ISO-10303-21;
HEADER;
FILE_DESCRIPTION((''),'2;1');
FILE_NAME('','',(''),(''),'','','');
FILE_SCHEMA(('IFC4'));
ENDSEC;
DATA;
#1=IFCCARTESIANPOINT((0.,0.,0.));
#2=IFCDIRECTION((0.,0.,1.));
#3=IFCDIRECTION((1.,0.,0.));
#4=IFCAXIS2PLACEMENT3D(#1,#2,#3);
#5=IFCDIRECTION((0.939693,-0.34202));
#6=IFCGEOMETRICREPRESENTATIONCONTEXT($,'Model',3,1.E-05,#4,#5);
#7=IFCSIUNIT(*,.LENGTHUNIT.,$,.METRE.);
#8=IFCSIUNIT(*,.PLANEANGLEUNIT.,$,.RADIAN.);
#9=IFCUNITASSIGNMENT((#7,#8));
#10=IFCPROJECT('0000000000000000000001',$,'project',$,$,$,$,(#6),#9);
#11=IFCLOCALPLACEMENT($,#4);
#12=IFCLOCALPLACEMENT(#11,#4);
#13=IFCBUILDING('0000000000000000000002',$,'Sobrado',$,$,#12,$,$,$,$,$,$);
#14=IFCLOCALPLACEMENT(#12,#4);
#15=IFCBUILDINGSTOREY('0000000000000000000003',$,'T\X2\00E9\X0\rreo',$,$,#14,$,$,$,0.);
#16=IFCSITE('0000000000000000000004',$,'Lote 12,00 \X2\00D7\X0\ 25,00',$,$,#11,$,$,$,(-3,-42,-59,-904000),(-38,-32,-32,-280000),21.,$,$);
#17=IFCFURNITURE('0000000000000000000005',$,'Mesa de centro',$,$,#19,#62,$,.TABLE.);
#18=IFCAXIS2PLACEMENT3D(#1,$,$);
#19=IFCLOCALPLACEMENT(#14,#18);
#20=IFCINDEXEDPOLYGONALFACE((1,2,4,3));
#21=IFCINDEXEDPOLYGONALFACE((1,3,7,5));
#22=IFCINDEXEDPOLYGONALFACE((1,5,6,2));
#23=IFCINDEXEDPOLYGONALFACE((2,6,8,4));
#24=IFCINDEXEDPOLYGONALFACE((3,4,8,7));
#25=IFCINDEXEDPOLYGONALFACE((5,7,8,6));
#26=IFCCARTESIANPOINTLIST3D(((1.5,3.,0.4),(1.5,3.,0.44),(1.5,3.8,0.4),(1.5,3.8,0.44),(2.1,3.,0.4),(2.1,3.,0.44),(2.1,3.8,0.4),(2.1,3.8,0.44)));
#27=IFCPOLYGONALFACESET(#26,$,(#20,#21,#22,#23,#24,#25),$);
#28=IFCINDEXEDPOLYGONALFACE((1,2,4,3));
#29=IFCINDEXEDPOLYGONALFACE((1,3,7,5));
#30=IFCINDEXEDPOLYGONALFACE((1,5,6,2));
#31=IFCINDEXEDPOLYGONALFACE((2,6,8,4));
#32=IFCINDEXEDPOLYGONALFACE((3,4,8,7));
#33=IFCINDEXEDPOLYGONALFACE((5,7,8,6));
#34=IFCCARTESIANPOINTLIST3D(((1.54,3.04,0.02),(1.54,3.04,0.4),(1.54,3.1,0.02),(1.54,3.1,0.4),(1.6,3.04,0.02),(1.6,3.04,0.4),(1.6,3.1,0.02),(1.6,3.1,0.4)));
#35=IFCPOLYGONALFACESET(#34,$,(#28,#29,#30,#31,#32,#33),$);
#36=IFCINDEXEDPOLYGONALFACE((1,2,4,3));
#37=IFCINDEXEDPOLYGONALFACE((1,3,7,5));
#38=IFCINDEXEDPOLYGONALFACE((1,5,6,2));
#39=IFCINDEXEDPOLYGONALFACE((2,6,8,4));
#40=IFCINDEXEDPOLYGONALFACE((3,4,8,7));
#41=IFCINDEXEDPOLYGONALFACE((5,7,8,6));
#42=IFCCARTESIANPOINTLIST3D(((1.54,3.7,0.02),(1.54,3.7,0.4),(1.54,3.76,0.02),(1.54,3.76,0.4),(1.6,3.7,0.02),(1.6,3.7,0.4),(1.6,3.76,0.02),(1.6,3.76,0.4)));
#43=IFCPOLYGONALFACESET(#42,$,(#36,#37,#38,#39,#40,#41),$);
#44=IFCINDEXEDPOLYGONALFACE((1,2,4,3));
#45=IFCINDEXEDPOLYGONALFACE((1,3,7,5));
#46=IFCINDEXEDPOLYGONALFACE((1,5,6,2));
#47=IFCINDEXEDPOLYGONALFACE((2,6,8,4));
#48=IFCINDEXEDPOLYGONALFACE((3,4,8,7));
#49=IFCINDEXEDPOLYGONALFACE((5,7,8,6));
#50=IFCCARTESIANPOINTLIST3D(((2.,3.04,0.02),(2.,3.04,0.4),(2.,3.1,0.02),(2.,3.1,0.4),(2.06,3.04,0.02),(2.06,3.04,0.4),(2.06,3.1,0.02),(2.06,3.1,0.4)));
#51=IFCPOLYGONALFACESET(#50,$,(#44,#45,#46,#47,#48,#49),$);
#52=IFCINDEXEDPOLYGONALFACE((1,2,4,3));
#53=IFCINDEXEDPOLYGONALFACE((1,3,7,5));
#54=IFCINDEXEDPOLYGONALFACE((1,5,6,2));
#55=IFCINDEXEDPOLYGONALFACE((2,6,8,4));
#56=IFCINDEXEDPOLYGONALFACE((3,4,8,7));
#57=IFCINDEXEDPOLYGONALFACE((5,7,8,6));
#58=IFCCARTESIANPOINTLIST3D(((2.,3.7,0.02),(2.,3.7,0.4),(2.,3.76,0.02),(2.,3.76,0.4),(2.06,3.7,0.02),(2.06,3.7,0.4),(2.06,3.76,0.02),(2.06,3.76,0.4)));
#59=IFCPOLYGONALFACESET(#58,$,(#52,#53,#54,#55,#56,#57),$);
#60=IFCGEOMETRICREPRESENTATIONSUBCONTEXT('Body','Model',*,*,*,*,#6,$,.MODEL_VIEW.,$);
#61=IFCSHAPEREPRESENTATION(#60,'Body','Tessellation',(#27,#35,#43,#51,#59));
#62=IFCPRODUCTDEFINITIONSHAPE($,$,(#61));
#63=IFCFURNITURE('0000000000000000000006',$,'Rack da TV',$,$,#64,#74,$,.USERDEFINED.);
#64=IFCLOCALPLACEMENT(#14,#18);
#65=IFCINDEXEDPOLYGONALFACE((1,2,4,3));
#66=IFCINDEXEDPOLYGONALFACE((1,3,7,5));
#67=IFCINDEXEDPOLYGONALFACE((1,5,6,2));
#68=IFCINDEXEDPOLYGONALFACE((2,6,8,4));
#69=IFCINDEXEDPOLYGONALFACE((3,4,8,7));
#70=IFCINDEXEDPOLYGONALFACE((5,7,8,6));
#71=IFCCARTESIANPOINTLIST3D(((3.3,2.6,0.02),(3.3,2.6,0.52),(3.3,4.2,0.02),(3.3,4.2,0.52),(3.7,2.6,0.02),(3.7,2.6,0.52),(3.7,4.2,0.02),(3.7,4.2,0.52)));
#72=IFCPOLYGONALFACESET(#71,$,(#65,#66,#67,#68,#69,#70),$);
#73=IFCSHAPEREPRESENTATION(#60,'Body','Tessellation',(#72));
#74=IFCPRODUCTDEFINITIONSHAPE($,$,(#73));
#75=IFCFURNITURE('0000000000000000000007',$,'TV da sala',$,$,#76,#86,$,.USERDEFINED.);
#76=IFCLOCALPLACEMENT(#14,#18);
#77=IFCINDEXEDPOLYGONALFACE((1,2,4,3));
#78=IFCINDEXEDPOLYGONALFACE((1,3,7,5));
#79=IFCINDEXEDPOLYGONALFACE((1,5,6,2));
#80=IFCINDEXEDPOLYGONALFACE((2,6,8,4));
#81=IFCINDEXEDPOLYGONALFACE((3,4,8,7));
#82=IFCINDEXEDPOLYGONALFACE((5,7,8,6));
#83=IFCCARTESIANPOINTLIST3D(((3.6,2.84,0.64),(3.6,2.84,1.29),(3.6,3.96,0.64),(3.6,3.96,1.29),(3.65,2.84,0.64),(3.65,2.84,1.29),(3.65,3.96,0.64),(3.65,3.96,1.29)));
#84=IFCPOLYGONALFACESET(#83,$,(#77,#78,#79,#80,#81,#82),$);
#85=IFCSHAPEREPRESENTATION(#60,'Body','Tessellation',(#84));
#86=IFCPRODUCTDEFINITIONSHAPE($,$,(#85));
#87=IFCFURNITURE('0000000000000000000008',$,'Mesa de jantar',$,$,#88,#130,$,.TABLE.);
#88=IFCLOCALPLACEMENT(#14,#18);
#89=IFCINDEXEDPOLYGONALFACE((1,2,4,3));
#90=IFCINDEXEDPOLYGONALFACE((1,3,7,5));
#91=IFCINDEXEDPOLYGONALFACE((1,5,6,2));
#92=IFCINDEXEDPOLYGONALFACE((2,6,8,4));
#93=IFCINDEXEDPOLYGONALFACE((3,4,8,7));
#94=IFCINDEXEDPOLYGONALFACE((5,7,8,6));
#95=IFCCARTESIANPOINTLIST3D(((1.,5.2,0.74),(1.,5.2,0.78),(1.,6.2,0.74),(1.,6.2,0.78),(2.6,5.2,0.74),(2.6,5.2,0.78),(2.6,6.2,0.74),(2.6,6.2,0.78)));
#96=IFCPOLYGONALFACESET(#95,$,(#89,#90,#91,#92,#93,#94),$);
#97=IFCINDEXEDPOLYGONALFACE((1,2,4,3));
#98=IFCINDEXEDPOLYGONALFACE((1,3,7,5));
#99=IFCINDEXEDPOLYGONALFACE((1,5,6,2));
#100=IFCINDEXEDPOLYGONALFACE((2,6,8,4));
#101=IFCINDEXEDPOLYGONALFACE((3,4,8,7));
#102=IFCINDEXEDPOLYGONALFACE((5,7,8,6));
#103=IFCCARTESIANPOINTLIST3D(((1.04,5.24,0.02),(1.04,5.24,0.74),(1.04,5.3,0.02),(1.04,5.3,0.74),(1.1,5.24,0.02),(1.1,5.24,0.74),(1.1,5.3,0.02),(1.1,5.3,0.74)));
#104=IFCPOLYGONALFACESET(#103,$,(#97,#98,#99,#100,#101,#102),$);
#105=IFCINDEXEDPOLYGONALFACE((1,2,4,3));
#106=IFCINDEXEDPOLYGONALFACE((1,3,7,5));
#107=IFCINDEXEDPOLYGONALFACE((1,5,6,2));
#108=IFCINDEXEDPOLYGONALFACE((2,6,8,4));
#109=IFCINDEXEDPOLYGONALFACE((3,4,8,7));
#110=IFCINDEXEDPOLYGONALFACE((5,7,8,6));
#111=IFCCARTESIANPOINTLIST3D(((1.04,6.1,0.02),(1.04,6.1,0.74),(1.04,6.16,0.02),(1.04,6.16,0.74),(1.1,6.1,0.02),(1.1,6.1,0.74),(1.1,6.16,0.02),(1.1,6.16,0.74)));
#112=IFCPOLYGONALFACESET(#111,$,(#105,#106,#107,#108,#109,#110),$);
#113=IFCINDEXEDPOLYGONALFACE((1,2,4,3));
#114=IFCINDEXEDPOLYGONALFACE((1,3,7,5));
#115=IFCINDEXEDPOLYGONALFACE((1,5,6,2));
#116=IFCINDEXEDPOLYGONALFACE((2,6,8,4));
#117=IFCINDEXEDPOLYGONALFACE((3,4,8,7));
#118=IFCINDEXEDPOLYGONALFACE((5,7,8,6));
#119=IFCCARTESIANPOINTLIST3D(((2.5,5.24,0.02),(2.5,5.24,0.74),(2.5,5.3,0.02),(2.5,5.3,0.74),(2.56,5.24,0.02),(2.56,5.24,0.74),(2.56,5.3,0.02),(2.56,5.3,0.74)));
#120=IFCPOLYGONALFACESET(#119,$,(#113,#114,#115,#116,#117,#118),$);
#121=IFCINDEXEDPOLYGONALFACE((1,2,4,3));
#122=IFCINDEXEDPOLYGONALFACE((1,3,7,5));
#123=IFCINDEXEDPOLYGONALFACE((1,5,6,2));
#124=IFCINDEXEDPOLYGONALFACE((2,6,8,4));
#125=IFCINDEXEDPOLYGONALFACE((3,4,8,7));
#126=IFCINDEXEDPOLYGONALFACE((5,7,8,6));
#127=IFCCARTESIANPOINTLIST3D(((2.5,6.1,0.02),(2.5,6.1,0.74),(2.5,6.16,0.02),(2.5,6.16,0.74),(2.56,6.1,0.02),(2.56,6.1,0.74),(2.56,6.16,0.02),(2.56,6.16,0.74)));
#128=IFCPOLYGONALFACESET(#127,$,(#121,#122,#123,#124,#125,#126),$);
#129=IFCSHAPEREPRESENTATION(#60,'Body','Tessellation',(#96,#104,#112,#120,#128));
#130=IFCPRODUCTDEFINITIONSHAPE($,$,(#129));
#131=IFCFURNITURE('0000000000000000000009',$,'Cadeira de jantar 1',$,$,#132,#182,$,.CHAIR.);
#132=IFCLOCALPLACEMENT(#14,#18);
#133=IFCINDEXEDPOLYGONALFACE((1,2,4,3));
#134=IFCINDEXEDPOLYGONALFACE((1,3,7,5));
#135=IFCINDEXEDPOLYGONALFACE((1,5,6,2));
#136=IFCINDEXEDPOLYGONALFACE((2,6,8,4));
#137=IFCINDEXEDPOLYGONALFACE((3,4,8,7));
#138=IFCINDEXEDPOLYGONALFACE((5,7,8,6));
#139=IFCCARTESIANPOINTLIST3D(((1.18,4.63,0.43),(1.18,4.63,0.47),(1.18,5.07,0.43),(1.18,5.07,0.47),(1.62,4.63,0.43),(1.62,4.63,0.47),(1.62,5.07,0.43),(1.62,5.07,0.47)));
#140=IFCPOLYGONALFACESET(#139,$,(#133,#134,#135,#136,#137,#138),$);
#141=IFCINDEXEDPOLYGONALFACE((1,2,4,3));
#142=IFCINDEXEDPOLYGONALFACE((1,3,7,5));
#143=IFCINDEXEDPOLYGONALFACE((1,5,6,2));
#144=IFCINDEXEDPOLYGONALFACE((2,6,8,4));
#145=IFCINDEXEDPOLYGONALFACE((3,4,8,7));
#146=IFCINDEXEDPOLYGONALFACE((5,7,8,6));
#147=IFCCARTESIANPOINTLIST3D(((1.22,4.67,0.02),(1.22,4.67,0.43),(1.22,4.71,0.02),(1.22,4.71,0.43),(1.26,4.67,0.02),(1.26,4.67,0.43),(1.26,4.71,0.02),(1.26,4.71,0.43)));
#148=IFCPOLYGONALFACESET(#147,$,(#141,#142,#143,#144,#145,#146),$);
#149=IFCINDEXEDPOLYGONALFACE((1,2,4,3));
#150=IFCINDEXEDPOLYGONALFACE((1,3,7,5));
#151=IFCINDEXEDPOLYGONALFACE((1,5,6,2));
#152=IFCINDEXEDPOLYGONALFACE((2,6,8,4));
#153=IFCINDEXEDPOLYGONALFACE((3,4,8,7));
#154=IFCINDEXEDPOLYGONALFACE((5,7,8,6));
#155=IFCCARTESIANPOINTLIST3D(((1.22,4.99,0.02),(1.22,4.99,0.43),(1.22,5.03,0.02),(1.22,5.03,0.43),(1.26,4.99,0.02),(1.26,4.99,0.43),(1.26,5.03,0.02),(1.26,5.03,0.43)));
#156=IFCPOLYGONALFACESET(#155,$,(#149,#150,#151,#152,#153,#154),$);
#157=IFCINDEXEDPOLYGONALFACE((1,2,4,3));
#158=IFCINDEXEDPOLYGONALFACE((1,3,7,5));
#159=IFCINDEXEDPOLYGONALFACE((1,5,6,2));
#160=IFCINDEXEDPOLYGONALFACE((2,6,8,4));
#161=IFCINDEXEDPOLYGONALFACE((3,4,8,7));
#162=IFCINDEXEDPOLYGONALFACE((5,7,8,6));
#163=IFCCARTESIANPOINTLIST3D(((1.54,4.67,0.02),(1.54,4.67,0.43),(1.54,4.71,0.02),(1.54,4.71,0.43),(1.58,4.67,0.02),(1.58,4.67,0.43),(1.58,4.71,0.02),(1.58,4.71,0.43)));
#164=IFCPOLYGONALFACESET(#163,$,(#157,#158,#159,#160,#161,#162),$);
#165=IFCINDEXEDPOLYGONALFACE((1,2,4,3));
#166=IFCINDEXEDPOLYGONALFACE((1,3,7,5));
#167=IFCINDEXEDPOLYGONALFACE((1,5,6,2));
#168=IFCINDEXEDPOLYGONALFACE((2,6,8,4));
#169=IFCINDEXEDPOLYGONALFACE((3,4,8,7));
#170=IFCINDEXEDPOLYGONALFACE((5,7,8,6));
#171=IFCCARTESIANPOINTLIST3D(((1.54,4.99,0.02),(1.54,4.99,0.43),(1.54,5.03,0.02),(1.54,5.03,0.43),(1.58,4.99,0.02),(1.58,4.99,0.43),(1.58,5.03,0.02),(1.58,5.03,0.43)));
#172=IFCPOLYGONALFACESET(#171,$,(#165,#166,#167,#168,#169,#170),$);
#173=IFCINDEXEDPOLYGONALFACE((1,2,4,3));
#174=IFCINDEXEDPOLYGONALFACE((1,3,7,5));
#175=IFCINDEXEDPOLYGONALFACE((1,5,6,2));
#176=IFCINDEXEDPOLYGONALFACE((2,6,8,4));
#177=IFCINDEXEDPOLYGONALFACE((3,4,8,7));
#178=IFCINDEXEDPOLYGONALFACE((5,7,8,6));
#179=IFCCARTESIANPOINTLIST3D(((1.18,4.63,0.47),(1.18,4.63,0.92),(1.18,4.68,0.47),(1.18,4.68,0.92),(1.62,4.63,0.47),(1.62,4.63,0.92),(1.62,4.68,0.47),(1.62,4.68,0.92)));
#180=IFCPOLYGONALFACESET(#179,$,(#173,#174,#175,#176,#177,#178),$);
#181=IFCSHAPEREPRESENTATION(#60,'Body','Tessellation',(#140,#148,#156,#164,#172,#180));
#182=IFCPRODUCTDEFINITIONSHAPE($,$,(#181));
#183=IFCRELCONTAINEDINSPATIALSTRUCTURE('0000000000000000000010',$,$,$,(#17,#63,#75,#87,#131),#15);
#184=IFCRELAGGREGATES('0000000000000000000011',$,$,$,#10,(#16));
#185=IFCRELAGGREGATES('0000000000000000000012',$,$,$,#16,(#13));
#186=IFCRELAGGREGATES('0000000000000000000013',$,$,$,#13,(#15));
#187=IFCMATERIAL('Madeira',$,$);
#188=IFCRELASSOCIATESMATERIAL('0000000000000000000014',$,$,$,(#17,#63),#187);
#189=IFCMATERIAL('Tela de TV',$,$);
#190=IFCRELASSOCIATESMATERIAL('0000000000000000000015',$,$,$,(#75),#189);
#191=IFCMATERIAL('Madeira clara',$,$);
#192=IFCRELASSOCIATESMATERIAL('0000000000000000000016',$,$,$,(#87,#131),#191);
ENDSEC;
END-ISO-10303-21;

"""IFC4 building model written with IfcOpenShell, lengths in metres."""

from ifc_helpers import new_model, si_unit, direction, frame, origin_with_axes, place, context, subcontext, project, spatial, line, indexed_curve, outline, extrude, material, element, save


model = new_model("IFC4")

# Units and contexts
model_context = context("Model", 3, precision=1e-05, world=origin_with_axes(), true_north=direction((0.939693, -0.34202)))
body_context = subcontext(model_context, "Body", "Model", "MODEL_VIEW")
ifc_project = project(units=[si_unit("LENGTHUNIT", "METRE"), si_unit("PLANEANGLEUNIT", "RADIAN")], contexts=[model_context])

# Site, building, storey
site_placement = place(None, origin_with_axes())
site = spatial("IfcSite", under=ifc_project, at=site_placement, Name="Lote 12,00 × 25,00", RefLatitude=(-3, -42, -59, -904000), RefLongitude=(-38, -32, -32, -280000), RefElevation=21.0)
building_placement = place(site_placement, origin_with_axes())
building = spatial("IfcBuilding", under=site, at=building_placement, Name="Sobrado")
storey_placement = place(building_placement, origin_with_axes())
storey = spatial("IfcBuildingStorey", under=building, at=storey_placement, Name="Térreo", Elevation=0.0)

# Shared definitions
ifc_material_1 = material(Name="Madeira")

# Furniture
furniture_1_placement = place(storey_placement, origin_with_axes())
element("IfcFurniture", 1, at=furniture_1_placement, inside=storey, material=ifc_material_1, Name="Mesa de centro", PredefinedType="TABLE", context=body_context, shape_type="SweptSolid", body=[
    extrude(outline(indexed_curve([(1.5, 3.0), (2.1, 3.0), (2.1, 3.8), (1.5, 3.8)], segments=[line(1, 2, 3, 4, 1)])), frame((0.0, 0.0, 0.4), z_axis=(0.0, 0.0, 1.0), x_axis=(1.0, 0.0, 0.0)), (0.0, 0.0, 1.0), 0.04),
    extrude(outline(indexed_curve([(1.54, 3.04), (1.6, 3.04), (1.6, 3.1), (1.54, 3.1)], segments=[line(1, 2, 3, 4, 1)])), frame((0.0, 0.0, 0.02), z_axis=(0.0, 0.0, 1.0), x_axis=(1.0, 0.0, 0.0)), (0.0, 0.0, 1.0), 0.38),
    extrude(outline(indexed_curve([(1.54, 3.7), (1.6, 3.7), (1.6, 3.76), (1.54, 3.76)], segments=[line(1, 2, 3, 4, 1)])), frame((0.0, 0.0, 0.02), z_axis=(0.0, 0.0, 1.0), x_axis=(1.0, 0.0, 0.0)), (0.0, 0.0, 1.0), 0.38),
    extrude(outline(indexed_curve([(2.0, 3.04), (2.06, 3.04), (2.06, 3.1), (2.0, 3.1)], segments=[line(1, 2, 3, 4, 1)])), frame((0.0, 0.0, 0.02), z_axis=(0.0, 0.0, 1.0), x_axis=(1.0, 0.0, 0.0)), (0.0, 0.0, 1.0), 0.38),
    extrude(outline(indexed_curve([(2.0, 3.7), (2.06, 3.7), (2.06, 3.76), (2.0, 3.76)], segments=[line(1, 2, 3, 4, 1)])), frame((0.0, 0.0, 0.02), z_axis=(0.0, 0.0, 1.0), x_axis=(1.0, 0.0, 0.0)), (0.0, 0.0, 1.0), 0.38),
])
furniture_2_placement = place(storey_placement, origin_with_axes())
element("IfcFurniture", 2, at=furniture_2_placement, inside=storey, material=ifc_material_1, Name="Rack da TV", PredefinedType="USERDEFINED", context=body_context, shape_type="SweptSolid", body=[
    extrude(outline(indexed_curve([(3.3, 2.6), (3.7, 2.6), (3.7, 4.2), (3.3, 4.2)], segments=[line(1, 2, 3, 4, 1)])), frame((0.0, 0.0, 0.02), z_axis=(0.0, 0.0, 1.0), x_axis=(1.0, 0.0, 0.0)), (0.0, 0.0, 1.0), 0.5),
])
ifc_material_2 = material(Name="Tela de TV")
furniture_3_placement = place(storey_placement, origin_with_axes())
element("IfcFurniture", 3, at=furniture_3_placement, inside=storey, material=ifc_material_2, Name="TV da sala", PredefinedType="USERDEFINED", context=body_context, shape_type="SweptSolid", body=[
    extrude(outline(indexed_curve([(3.6, 2.84), (3.65, 2.84), (3.65, 3.96), (3.6, 3.96)], segments=[line(1, 2, 3, 4, 1)])), frame((0.0, 0.0, 0.64), z_axis=(0.0, 0.0, 1.0), x_axis=(1.0, 0.0, 0.0)), (0.0, 0.0, 1.0), 0.65),
])
ifc_material_3 = material(Name="Madeira clara")
furniture_4_placement = place(storey_placement, origin_with_axes())
element("IfcFurniture", 4, at=furniture_4_placement, inside=storey, material=ifc_material_3, Name="Mesa de jantar", PredefinedType="TABLE", context=body_context, shape_type="SweptSolid", body=[
    extrude(outline(indexed_curve([(1.0, 5.2), (2.6, 5.2), (2.6, 6.2), (1.0, 6.2)], segments=[line(1, 2, 3, 4, 1)])), frame((0.0, 0.0, 0.74), z_axis=(0.0, 0.0, 1.0), x_axis=(1.0, 0.0, 0.0)), (0.0, 0.0, 1.0), 0.04),
    extrude(outline(indexed_curve([(1.04, 5.24), (1.1, 5.24), (1.1, 5.3), (1.04, 5.3)], segments=[line(1, 2, 3, 4, 1)])), frame((0.0, 0.0, 0.02), z_axis=(0.0, 0.0, 1.0), x_axis=(1.0, 0.0, 0.0)), (0.0, 0.0, 1.0), 0.72),
    extrude(outline(indexed_curve([(1.04, 6.1), (1.1, 6.1), (1.1, 6.16), (1.04, 6.16)], segments=[line(1, 2, 3, 4, 1)])), frame((0.0, 0.0, 0.02), z_axis=(0.0, 0.0, 1.0), x_axis=(1.0, 0.0, 0.0)), (0.0, 0.0, 1.0), 0.72),
    extrude(outline(indexed_curve([(2.5, 5.24), (2.56, 5.24), (2.56, 5.3), (2.5, 5.3)], segments=[line(1, 2, 3, 4, 1)])), frame((0.0, 0.0, 0.02), z_axis=(0.0, 0.0, 1.0), x_axis=(1.0, 0.0, 0.0)), (0.0, 0.0, 1.0), 0.72),
    extrude(outline(indexed_curve([(2.5, 6.1), (2.56, 6.1), (2.56, 6.16), (2.5, 6.16)], segments=[line(1, 2, 3, 4, 1)])), frame((0.0, 0.0, 0.02), z_axis=(0.0, 0.0, 1.0), x_axis=(1.0, 0.0, 0.0)), (0.0, 0.0, 1.0), 0.72),
])
furniture_5_placement = place(storey_placement, origin_with_axes())
element("IfcFurniture", 5, at=furniture_5_placement, inside=storey, material=ifc_material_3, Name="Cadeira de jantar 1", PredefinedType="CHAIR", context=body_context, shape_type="SweptSolid", body=[
    extrude(outline(indexed_curve([(1.18, 4.63), (1.62, 4.63), (1.62, 5.07), (1.18, 5.07)], segments=[line(1, 2, 3, 4, 1)])), frame((0.0, 0.0, 0.43), z_axis=(0.0, 0.0, 1.0), x_axis=(1.0, 0.0, 0.0)), (0.0, 0.0, 1.0), 0.04),
    extrude(outline(indexed_curve([(1.22, 4.67), (1.26, 4.67), (1.26, 4.71), (1.22, 4.71)], segments=[line(1, 2, 3, 4, 1)])), frame((0.0, 0.0, 0.02), z_axis=(0.0, 0.0, 1.0), x_axis=(1.0, 0.0, 0.0)), (0.0, 0.0, 1.0), 0.41),
    extrude(outline(indexed_curve([(1.22, 4.99), (1.26, 4.99), (1.26, 5.03), (1.22, 5.03)], segments=[line(1, 2, 3, 4, 1)])), frame((0.0, 0.0, 0.02), z_axis=(0.0, 0.0, 1.0), x_axis=(1.0, 0.0, 0.0)), (0.0, 0.0, 1.0), 0.41),
    extrude(outline(indexed_curve([(1.54, 4.67), (1.58, 4.67), (1.58, 4.71), (1.54, 4.71)], segments=[line(1, 2, 3, 4, 1)])), frame((0.0, 0.0, 0.02), z_axis=(0.0, 0.0, 1.0), x_axis=(1.0, 0.0, 0.0)), (0.0, 0.0, 1.0), 0.41),
    extrude(outline(indexed_curve([(1.54, 4.99), (1.58, 4.99), (1.58, 5.03), (1.54, 5.03)], segments=[line(1, 2, 3, 4, 1)])), frame((0.0, 0.0, 0.02), z_axis=(0.0, 0.0, 1.0), x_axis=(1.0, 0.0, 0.0)), (0.0, 0.0, 1.0), 0.41),
    extrude(outline(indexed_curve([(1.18, 4.63), (1.62, 4.63), (1.62, 4.68), (1.18, 4.68)], segments=[line(1, 2, 3, 4, 1)])), frame((0.0, 0.0, 0.47), z_axis=(0.0, 0.0, 1.0), x_axis=(1.0, 0.0, 0.0)), (0.0, 0.0, 1.0), 0.45),
])

save(model, "model.ifc")
